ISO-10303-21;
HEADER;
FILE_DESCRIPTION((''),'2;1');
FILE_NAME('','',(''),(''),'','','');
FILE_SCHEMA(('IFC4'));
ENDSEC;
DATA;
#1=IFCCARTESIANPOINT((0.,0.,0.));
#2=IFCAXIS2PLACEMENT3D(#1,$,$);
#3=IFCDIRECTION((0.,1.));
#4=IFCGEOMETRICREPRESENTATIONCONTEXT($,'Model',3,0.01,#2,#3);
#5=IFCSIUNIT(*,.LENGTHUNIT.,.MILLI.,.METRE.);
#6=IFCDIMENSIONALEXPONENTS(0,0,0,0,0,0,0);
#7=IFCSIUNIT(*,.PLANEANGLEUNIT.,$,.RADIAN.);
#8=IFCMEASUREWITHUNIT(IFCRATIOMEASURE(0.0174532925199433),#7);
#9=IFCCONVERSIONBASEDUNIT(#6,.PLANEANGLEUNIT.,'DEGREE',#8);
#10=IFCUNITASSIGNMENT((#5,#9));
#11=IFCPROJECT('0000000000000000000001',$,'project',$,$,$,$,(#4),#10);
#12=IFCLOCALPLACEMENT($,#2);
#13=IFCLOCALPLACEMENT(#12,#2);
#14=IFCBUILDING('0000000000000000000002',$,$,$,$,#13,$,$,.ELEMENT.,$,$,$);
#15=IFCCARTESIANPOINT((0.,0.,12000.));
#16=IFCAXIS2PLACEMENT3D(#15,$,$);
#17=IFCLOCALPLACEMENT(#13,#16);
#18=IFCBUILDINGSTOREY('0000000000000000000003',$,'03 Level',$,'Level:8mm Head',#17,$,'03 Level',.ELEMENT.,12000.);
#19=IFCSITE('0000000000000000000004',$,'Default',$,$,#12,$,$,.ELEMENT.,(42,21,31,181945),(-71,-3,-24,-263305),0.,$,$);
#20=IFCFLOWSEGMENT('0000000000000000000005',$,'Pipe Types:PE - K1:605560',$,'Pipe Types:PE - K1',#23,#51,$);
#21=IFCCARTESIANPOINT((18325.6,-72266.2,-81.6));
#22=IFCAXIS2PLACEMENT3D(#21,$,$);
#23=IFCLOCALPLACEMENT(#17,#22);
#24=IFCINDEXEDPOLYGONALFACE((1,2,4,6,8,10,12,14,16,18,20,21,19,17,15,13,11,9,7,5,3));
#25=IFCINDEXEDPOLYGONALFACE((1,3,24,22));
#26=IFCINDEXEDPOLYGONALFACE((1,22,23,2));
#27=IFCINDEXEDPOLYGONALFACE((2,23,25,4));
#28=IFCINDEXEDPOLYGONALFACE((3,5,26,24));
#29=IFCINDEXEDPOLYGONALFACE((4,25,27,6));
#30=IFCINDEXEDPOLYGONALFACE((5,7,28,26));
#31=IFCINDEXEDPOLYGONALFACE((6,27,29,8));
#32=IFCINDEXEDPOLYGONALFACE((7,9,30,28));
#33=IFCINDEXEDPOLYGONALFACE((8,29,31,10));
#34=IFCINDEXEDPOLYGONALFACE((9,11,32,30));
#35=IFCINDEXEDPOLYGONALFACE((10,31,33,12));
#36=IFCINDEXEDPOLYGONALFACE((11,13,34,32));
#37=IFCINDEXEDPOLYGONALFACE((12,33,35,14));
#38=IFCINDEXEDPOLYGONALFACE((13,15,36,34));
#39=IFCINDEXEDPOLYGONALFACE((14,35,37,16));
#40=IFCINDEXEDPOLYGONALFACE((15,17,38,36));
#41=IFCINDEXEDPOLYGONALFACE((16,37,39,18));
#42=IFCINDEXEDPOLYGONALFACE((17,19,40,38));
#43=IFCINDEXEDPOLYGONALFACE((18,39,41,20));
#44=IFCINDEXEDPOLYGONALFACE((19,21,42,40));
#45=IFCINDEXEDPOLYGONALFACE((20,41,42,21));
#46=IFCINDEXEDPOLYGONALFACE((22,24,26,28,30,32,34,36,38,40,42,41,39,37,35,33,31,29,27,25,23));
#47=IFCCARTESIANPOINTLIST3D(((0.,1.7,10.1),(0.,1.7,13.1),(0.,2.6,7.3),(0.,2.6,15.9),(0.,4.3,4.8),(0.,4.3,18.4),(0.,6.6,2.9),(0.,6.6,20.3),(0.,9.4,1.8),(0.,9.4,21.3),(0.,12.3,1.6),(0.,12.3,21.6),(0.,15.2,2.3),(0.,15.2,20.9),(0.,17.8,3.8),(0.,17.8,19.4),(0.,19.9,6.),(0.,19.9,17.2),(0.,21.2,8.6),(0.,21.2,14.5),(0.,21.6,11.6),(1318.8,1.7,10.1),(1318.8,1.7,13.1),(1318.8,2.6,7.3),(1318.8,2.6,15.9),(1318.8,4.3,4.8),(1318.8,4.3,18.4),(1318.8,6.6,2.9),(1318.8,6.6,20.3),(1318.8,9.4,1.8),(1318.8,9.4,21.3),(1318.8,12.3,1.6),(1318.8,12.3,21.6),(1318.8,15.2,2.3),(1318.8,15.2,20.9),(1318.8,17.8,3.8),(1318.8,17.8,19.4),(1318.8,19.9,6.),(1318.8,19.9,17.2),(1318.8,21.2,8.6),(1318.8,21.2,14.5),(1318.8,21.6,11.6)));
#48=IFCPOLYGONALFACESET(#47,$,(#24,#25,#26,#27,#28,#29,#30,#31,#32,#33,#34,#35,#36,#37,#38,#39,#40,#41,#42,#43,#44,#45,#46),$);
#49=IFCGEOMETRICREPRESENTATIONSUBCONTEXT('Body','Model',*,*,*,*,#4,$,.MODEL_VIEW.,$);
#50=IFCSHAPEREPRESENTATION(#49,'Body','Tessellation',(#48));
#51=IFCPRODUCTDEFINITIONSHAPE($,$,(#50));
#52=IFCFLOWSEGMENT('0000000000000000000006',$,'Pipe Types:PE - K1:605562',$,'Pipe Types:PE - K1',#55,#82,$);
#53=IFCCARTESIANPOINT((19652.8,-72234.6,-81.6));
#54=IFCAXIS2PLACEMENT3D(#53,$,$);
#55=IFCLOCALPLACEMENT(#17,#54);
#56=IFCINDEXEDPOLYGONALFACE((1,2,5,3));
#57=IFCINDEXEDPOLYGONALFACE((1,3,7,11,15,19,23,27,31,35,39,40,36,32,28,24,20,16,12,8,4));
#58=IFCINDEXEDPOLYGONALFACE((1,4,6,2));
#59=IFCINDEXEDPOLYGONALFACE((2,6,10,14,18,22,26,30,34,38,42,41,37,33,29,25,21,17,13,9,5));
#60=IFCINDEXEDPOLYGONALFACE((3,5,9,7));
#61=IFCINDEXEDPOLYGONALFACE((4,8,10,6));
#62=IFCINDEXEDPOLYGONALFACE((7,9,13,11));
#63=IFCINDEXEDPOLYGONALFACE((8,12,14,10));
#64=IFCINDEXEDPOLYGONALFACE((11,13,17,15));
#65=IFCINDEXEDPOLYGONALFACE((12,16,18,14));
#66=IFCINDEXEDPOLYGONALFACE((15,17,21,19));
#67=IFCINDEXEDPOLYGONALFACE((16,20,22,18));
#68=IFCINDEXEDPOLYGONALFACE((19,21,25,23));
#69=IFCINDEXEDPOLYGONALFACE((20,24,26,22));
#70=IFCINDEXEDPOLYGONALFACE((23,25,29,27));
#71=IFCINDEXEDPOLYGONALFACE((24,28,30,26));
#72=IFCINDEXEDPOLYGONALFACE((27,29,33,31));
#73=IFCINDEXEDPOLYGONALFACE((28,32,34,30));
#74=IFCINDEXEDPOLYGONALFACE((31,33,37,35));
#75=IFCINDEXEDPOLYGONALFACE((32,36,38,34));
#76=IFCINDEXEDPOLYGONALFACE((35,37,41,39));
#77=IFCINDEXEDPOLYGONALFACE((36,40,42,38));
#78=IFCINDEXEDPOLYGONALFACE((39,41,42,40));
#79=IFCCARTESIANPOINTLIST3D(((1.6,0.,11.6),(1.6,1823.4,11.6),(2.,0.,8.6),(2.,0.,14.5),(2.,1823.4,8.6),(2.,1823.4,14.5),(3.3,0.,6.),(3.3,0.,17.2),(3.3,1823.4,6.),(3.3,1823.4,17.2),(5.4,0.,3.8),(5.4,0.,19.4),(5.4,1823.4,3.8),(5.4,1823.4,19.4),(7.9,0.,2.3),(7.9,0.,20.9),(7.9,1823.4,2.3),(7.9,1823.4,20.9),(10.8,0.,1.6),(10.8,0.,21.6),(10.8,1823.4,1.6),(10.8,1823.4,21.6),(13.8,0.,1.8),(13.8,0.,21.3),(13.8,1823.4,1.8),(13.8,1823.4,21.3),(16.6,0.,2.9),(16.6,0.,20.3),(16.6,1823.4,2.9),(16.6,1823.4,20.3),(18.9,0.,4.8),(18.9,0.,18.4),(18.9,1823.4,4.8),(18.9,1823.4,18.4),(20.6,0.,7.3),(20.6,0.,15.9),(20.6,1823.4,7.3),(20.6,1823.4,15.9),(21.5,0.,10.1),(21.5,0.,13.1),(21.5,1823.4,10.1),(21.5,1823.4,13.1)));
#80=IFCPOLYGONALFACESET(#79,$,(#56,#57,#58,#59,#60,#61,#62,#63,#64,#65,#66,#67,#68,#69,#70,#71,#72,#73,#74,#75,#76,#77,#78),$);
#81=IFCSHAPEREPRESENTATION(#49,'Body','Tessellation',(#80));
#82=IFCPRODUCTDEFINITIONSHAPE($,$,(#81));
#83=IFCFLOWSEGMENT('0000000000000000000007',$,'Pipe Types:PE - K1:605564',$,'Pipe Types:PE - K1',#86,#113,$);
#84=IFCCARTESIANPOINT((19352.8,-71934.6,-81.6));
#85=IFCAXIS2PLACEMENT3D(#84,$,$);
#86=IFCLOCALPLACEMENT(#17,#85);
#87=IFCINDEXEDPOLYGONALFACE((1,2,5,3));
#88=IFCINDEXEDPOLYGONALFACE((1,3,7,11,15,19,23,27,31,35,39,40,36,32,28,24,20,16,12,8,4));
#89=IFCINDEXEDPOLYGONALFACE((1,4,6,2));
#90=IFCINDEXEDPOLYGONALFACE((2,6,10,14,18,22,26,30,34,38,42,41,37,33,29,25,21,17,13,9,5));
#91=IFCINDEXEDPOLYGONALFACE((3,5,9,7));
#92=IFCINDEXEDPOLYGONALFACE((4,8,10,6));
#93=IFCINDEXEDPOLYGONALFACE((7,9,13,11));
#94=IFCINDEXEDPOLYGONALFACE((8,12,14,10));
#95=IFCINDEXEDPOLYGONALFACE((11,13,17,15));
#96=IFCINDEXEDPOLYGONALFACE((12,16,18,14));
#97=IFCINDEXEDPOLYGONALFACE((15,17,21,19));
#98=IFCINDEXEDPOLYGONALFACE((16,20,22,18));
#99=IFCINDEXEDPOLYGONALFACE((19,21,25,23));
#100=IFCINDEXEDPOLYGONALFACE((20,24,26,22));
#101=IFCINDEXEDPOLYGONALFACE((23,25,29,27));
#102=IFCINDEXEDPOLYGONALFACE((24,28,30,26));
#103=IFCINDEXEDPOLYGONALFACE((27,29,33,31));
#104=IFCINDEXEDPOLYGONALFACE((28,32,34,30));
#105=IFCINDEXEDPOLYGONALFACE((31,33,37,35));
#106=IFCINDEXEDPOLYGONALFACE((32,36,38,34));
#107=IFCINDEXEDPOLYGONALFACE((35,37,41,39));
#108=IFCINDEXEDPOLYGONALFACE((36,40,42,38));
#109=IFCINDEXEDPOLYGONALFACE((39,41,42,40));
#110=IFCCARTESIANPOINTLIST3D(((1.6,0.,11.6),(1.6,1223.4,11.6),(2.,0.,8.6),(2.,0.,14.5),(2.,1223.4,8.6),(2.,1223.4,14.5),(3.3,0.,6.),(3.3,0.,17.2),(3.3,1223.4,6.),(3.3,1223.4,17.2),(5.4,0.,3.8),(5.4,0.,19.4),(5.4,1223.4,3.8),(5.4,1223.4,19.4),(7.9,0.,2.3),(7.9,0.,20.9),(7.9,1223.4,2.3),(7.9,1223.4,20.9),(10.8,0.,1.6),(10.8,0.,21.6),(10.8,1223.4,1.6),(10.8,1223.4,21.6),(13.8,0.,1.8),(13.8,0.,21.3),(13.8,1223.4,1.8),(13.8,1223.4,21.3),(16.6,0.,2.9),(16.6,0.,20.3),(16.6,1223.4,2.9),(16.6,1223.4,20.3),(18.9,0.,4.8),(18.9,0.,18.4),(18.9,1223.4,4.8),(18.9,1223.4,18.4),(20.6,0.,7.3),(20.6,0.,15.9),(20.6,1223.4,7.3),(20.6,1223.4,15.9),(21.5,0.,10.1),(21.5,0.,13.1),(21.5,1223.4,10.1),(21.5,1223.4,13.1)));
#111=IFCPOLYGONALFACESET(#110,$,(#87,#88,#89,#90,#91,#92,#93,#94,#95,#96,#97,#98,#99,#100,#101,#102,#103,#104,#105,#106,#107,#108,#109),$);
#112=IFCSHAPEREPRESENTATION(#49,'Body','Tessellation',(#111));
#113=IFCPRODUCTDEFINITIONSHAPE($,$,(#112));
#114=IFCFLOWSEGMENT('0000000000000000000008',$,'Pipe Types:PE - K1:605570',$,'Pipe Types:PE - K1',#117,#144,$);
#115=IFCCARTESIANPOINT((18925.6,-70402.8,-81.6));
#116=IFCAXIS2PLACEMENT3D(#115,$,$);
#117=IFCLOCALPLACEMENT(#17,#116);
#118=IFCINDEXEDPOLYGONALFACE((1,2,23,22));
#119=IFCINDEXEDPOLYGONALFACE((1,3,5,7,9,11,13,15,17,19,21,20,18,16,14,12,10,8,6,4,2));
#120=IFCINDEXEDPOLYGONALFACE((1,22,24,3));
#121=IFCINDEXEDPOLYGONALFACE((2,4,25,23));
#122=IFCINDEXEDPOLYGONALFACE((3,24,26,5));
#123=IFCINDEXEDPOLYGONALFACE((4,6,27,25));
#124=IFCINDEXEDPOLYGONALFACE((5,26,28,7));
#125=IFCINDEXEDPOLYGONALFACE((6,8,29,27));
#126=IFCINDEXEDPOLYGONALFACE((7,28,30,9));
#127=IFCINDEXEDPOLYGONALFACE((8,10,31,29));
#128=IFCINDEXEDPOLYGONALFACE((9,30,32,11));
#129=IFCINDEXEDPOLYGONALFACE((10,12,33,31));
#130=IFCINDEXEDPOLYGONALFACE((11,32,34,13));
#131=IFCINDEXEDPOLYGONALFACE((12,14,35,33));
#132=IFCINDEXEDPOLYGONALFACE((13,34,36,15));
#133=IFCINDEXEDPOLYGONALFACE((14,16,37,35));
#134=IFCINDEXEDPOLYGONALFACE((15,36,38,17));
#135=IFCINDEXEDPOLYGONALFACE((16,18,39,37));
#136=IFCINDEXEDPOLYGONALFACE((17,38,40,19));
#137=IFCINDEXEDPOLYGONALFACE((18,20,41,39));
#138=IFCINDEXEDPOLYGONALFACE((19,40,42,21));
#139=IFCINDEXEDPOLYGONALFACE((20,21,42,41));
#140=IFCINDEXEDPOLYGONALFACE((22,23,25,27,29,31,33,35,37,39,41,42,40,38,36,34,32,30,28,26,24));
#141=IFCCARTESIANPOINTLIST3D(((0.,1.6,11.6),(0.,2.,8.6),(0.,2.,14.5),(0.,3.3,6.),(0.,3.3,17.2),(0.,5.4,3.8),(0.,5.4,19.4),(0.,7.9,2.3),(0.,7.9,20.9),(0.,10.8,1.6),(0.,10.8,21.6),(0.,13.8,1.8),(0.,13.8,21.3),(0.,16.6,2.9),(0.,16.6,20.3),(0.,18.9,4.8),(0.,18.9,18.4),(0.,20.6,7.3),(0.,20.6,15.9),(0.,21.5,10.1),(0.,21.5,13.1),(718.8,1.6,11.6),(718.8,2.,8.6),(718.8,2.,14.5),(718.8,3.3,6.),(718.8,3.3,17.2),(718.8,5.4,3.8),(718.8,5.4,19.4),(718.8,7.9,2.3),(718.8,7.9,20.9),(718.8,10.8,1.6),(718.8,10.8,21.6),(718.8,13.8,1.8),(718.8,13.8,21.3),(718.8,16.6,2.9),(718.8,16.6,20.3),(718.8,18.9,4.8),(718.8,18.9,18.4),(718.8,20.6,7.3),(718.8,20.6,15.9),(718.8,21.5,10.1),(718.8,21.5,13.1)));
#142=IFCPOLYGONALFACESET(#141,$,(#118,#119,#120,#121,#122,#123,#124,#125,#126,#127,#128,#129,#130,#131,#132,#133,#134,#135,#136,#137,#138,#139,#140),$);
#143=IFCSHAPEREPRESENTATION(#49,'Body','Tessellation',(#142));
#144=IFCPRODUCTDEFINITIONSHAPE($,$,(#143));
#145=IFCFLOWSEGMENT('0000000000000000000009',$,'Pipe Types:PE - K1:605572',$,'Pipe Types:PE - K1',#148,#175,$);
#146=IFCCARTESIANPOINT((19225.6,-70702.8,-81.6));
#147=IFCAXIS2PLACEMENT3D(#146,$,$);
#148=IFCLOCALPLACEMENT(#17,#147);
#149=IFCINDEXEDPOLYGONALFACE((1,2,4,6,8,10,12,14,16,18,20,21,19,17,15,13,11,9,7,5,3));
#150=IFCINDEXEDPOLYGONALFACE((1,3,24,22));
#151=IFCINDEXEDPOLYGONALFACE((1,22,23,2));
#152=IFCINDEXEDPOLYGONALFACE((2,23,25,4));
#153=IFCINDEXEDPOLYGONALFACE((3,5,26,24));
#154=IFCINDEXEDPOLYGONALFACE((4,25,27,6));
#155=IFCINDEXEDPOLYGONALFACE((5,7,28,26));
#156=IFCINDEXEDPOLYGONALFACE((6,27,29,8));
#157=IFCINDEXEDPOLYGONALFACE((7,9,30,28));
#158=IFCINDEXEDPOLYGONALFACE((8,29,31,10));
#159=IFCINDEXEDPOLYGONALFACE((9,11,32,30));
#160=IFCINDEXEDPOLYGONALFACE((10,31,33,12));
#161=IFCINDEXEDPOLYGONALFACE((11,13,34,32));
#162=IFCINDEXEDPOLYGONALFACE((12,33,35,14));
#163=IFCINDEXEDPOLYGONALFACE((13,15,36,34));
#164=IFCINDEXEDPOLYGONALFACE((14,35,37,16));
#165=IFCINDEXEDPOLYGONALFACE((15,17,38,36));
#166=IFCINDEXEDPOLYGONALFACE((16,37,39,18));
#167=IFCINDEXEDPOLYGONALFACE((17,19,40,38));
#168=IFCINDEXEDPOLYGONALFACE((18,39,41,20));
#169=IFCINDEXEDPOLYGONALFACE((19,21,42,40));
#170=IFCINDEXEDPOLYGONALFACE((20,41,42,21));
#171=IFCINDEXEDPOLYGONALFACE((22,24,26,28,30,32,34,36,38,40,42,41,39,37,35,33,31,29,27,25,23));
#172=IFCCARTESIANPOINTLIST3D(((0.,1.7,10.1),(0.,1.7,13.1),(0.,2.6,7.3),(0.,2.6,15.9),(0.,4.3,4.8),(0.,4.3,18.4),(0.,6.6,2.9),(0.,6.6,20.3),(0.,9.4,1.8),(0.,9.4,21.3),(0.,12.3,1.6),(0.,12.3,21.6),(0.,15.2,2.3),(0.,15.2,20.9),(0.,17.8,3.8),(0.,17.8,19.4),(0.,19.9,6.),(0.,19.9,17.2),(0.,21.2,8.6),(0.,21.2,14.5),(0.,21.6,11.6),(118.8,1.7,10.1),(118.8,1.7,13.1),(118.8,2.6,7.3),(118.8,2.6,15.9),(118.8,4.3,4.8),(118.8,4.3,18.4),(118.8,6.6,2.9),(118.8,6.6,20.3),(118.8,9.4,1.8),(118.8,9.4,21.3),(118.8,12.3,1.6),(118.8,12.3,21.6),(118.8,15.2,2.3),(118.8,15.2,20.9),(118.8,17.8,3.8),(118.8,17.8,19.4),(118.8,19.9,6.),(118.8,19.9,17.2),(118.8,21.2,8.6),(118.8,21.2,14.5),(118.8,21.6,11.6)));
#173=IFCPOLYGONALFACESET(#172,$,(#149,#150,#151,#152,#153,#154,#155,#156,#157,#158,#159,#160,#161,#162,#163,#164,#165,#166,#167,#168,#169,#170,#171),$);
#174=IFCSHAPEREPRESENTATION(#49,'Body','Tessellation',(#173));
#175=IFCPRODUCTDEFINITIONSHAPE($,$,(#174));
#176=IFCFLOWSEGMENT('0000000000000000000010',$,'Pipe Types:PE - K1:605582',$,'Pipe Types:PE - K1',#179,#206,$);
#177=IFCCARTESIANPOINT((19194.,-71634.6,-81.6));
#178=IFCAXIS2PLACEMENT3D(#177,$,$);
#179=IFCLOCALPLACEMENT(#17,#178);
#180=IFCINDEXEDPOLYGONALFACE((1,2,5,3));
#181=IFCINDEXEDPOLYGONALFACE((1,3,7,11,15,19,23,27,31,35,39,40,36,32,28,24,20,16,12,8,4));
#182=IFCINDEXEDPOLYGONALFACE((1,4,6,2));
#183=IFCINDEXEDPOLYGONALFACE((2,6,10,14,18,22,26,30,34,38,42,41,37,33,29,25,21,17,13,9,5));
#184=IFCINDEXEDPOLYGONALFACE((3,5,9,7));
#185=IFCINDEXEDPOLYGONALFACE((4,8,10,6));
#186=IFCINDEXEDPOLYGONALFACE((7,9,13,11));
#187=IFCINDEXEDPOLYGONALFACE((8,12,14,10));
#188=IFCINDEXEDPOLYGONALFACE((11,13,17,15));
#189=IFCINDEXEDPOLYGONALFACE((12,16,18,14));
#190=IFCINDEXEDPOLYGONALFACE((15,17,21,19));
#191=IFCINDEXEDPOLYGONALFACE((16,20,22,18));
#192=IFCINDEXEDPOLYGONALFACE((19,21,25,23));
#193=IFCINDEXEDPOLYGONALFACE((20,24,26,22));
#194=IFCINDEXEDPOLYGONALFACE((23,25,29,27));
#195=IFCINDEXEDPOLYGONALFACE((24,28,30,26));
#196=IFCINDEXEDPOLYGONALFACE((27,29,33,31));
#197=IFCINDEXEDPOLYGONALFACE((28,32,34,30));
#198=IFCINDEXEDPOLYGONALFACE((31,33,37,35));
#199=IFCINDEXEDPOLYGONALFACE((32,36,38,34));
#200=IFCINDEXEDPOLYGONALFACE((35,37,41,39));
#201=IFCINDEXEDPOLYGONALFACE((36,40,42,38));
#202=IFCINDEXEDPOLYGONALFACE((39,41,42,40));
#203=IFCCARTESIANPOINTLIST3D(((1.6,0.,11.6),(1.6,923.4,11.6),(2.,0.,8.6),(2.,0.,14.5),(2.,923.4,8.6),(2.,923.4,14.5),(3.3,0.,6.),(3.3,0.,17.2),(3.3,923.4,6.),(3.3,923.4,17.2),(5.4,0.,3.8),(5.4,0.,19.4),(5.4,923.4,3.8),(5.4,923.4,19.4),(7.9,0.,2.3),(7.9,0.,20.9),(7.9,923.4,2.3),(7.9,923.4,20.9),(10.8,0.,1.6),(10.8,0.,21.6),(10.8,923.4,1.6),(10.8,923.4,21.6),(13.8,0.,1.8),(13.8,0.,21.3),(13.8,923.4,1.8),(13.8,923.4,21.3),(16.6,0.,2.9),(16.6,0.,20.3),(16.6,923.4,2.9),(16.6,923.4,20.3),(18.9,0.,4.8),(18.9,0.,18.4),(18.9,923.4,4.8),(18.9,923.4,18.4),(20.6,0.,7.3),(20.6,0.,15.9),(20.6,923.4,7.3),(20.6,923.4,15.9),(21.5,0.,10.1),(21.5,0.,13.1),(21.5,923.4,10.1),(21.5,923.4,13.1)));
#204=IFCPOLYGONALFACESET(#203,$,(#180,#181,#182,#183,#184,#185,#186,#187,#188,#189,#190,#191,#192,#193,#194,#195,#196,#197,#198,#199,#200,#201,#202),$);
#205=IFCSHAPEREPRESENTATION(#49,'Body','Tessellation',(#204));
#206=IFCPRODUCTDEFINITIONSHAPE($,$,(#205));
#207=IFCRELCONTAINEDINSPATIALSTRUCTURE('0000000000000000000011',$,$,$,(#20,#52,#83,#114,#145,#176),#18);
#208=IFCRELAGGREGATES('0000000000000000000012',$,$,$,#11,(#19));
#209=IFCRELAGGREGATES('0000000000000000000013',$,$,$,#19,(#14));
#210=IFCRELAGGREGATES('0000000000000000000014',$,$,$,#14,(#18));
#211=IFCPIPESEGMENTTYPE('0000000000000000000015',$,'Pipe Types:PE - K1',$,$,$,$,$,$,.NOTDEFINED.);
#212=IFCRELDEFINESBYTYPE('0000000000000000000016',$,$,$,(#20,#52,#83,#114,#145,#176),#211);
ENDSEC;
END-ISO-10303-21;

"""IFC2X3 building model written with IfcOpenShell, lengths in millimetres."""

from ifc_helpers import new_model, entity, si_unit, converted_unit, direction, frame, frame_2d, origin, origin_2d_with_axis, place, context, subcontext, project, spatial, circle, extrude, type_object, element, save


model = new_model("IFC2X3")

# Units and contexts
model_context = context("Model", 3, precision=0.01, world=origin(), true_north=direction((0.0, 1.0)))
body_context = subcontext(model_context, "Body", "Model", "MODEL_VIEW")
ifc_project = project(units=[si_unit("LENGTHUNIT", "METRE", prefix="MILLI"), converted_unit("PLANEANGLEUNIT", "DEGREE", entity("IfcRatioMeasure", 0.0174532925199433), si_unit("PLANEANGLEUNIT", "RADIAN"), dimensions=[0, 0, 0, 0, 0, 0, 0])], contexts=[model_context])

# Site, building, storey
site_placement = place(None, origin())
site = spatial("IfcSite", under=ifc_project, at=site_placement, Name="Default", CompositionType="ELEMENT", RefLatitude=(42, 21, 31, 181945), RefLongitude=(-71, -3, -24, -263305), RefElevation=0.0)
building_placement = place(site_placement, origin())
building = spatial("IfcBuilding", under=site, at=building_placement, CompositionType="ELEMENT")
storey_placement = place(building_placement, frame((0.0, 0.0, 12000.0)))
storey = spatial("IfcBuildingStorey", under=building, at=storey_placement, Name="03 Level", ObjectType="Level:8mm Head", LongName="03 Level", CompositionType="ELEMENT", Elevation=12000.0)

# Flow segments
pipe_segment_type = type_object("IfcPipeSegmentType", Name="Pipe Types:PE - K1", PredefinedType="NOTDEFINED")
flow_segment_1_placement = place(storey_placement, frame((18325.6, -72266.2, -81.6)))
element("IfcFlowSegment", 1, at=flow_segment_1_placement, inside=storey, type_object=pipe_segment_type, Name="Pipe Types:PE - K1:605560", ObjectType="Pipe Types:PE - K1", context=body_context, shape_type="SweptSolid", body=[
    extrude(circle(Radius=10.0, at=frame_2d((0.0, 0.0), x_axis=(1.0, 0.0))), frame((0.0, 11.6, 11.6), z_axis=(1.0, 0.0, 0.0), x_axis=(0.0, 1.0, 0.0)), (0.0, 0.0, 1.0), 1318.8),
])
flow_segment_2_placement = place(storey_placement, frame((19652.8, -72234.6, -81.6)))
element("IfcFlowSegment", 2, at=flow_segment_2_placement, inside=storey, type_object=pipe_segment_type, Name="Pipe Types:PE - K1:605562", ObjectType="Pipe Types:PE - K1", context=body_context, shape_type="SweptSolid", body=[
    extrude(circle(Radius=10.0, at=frame_2d((0.0, 0.0), x_axis=(1.0, 0.0))), frame((11.6, 0.0, 11.6), z_axis=(0.0, 1.0, 0.0), x_axis=(-1.0, 0.0, 0.0)), (0.0, 0.0, 1.0), 1823.4),
])
flow_segment_3_placement = place(storey_placement, frame((19352.8, -71934.6, -81.6)))
element("IfcFlowSegment", 3, at=flow_segment_3_placement, inside=storey, type_object=pipe_segment_type, Name="Pipe Types:PE - K1:605564", ObjectType="Pipe Types:PE - K1", context=body_context, shape_type="SweptSolid", body=[
    extrude(circle(Radius=10.0, at=frame_2d((0.0, 0.0), x_axis=(1.0, 0.0))), frame((11.6, 0.0, 11.6), z_axis=(0.0, 1.0, 0.0), x_axis=(-1.0, 0.0, 0.0)), (0.0, 0.0, 1.0), 1223.4),
])
flow_segment_4_placement = place(storey_placement, frame((18925.6, -70402.8, -81.6)))
element("IfcFlowSegment", 4, at=flow_segment_4_placement, inside=storey, type_object=pipe_segment_type, Name="Pipe Types:PE - K1:605570", ObjectType="Pipe Types:PE - K1", context=body_context, shape_type="SweptSolid", body=[
    extrude(circle(Radius=10.0, at=origin_2d_with_axis()), frame((0.0, 11.6, 11.6), z_axis=(1.0, 0.0, 0.0), x_axis=(0.0, -1.0, 0.0)), (0.0, 0.0, 1.0), 718.8),
])
flow_segment_5_placement = place(storey_placement, frame((19225.6, -70702.8, -81.6)))
element("IfcFlowSegment", 5, at=flow_segment_5_placement, inside=storey, type_object=pipe_segment_type, Name="Pipe Types:PE - K1:605572", ObjectType="Pipe Types:PE - K1", context=body_context, shape_type="SweptSolid", body=[
    extrude(circle(Radius=10.0, at=frame_2d((0.0, 0.0), x_axis=(1.0, 0.0))), frame((0.0, 11.6, 11.6), z_axis=(1.0, 0.0, 0.0), x_axis=(0.0, 1.0, 0.0)), (0.0, 0.0, 1.0), 118.8),
])
flow_segment_6_placement = place(storey_placement, frame((19194.0, -71634.6, -81.6)))
element("IfcFlowSegment", 6, at=flow_segment_6_placement, inside=storey, type_object=pipe_segment_type, Name="Pipe Types:PE - K1:605582", ObjectType="Pipe Types:PE - K1", context=body_context, shape_type="SweptSolid", body=[
    extrude(circle(Radius=10.0, at=frame_2d((0.0, 0.0), x_axis=(1.0, 0.0))), frame((11.6, 0.0, 11.6), z_axis=(0.0, 1.0, 0.0), x_axis=(-1.0, 0.0, 0.0)), (0.0, 0.0, 1.0), 923.4),
])

save(model, "model.ifc")
